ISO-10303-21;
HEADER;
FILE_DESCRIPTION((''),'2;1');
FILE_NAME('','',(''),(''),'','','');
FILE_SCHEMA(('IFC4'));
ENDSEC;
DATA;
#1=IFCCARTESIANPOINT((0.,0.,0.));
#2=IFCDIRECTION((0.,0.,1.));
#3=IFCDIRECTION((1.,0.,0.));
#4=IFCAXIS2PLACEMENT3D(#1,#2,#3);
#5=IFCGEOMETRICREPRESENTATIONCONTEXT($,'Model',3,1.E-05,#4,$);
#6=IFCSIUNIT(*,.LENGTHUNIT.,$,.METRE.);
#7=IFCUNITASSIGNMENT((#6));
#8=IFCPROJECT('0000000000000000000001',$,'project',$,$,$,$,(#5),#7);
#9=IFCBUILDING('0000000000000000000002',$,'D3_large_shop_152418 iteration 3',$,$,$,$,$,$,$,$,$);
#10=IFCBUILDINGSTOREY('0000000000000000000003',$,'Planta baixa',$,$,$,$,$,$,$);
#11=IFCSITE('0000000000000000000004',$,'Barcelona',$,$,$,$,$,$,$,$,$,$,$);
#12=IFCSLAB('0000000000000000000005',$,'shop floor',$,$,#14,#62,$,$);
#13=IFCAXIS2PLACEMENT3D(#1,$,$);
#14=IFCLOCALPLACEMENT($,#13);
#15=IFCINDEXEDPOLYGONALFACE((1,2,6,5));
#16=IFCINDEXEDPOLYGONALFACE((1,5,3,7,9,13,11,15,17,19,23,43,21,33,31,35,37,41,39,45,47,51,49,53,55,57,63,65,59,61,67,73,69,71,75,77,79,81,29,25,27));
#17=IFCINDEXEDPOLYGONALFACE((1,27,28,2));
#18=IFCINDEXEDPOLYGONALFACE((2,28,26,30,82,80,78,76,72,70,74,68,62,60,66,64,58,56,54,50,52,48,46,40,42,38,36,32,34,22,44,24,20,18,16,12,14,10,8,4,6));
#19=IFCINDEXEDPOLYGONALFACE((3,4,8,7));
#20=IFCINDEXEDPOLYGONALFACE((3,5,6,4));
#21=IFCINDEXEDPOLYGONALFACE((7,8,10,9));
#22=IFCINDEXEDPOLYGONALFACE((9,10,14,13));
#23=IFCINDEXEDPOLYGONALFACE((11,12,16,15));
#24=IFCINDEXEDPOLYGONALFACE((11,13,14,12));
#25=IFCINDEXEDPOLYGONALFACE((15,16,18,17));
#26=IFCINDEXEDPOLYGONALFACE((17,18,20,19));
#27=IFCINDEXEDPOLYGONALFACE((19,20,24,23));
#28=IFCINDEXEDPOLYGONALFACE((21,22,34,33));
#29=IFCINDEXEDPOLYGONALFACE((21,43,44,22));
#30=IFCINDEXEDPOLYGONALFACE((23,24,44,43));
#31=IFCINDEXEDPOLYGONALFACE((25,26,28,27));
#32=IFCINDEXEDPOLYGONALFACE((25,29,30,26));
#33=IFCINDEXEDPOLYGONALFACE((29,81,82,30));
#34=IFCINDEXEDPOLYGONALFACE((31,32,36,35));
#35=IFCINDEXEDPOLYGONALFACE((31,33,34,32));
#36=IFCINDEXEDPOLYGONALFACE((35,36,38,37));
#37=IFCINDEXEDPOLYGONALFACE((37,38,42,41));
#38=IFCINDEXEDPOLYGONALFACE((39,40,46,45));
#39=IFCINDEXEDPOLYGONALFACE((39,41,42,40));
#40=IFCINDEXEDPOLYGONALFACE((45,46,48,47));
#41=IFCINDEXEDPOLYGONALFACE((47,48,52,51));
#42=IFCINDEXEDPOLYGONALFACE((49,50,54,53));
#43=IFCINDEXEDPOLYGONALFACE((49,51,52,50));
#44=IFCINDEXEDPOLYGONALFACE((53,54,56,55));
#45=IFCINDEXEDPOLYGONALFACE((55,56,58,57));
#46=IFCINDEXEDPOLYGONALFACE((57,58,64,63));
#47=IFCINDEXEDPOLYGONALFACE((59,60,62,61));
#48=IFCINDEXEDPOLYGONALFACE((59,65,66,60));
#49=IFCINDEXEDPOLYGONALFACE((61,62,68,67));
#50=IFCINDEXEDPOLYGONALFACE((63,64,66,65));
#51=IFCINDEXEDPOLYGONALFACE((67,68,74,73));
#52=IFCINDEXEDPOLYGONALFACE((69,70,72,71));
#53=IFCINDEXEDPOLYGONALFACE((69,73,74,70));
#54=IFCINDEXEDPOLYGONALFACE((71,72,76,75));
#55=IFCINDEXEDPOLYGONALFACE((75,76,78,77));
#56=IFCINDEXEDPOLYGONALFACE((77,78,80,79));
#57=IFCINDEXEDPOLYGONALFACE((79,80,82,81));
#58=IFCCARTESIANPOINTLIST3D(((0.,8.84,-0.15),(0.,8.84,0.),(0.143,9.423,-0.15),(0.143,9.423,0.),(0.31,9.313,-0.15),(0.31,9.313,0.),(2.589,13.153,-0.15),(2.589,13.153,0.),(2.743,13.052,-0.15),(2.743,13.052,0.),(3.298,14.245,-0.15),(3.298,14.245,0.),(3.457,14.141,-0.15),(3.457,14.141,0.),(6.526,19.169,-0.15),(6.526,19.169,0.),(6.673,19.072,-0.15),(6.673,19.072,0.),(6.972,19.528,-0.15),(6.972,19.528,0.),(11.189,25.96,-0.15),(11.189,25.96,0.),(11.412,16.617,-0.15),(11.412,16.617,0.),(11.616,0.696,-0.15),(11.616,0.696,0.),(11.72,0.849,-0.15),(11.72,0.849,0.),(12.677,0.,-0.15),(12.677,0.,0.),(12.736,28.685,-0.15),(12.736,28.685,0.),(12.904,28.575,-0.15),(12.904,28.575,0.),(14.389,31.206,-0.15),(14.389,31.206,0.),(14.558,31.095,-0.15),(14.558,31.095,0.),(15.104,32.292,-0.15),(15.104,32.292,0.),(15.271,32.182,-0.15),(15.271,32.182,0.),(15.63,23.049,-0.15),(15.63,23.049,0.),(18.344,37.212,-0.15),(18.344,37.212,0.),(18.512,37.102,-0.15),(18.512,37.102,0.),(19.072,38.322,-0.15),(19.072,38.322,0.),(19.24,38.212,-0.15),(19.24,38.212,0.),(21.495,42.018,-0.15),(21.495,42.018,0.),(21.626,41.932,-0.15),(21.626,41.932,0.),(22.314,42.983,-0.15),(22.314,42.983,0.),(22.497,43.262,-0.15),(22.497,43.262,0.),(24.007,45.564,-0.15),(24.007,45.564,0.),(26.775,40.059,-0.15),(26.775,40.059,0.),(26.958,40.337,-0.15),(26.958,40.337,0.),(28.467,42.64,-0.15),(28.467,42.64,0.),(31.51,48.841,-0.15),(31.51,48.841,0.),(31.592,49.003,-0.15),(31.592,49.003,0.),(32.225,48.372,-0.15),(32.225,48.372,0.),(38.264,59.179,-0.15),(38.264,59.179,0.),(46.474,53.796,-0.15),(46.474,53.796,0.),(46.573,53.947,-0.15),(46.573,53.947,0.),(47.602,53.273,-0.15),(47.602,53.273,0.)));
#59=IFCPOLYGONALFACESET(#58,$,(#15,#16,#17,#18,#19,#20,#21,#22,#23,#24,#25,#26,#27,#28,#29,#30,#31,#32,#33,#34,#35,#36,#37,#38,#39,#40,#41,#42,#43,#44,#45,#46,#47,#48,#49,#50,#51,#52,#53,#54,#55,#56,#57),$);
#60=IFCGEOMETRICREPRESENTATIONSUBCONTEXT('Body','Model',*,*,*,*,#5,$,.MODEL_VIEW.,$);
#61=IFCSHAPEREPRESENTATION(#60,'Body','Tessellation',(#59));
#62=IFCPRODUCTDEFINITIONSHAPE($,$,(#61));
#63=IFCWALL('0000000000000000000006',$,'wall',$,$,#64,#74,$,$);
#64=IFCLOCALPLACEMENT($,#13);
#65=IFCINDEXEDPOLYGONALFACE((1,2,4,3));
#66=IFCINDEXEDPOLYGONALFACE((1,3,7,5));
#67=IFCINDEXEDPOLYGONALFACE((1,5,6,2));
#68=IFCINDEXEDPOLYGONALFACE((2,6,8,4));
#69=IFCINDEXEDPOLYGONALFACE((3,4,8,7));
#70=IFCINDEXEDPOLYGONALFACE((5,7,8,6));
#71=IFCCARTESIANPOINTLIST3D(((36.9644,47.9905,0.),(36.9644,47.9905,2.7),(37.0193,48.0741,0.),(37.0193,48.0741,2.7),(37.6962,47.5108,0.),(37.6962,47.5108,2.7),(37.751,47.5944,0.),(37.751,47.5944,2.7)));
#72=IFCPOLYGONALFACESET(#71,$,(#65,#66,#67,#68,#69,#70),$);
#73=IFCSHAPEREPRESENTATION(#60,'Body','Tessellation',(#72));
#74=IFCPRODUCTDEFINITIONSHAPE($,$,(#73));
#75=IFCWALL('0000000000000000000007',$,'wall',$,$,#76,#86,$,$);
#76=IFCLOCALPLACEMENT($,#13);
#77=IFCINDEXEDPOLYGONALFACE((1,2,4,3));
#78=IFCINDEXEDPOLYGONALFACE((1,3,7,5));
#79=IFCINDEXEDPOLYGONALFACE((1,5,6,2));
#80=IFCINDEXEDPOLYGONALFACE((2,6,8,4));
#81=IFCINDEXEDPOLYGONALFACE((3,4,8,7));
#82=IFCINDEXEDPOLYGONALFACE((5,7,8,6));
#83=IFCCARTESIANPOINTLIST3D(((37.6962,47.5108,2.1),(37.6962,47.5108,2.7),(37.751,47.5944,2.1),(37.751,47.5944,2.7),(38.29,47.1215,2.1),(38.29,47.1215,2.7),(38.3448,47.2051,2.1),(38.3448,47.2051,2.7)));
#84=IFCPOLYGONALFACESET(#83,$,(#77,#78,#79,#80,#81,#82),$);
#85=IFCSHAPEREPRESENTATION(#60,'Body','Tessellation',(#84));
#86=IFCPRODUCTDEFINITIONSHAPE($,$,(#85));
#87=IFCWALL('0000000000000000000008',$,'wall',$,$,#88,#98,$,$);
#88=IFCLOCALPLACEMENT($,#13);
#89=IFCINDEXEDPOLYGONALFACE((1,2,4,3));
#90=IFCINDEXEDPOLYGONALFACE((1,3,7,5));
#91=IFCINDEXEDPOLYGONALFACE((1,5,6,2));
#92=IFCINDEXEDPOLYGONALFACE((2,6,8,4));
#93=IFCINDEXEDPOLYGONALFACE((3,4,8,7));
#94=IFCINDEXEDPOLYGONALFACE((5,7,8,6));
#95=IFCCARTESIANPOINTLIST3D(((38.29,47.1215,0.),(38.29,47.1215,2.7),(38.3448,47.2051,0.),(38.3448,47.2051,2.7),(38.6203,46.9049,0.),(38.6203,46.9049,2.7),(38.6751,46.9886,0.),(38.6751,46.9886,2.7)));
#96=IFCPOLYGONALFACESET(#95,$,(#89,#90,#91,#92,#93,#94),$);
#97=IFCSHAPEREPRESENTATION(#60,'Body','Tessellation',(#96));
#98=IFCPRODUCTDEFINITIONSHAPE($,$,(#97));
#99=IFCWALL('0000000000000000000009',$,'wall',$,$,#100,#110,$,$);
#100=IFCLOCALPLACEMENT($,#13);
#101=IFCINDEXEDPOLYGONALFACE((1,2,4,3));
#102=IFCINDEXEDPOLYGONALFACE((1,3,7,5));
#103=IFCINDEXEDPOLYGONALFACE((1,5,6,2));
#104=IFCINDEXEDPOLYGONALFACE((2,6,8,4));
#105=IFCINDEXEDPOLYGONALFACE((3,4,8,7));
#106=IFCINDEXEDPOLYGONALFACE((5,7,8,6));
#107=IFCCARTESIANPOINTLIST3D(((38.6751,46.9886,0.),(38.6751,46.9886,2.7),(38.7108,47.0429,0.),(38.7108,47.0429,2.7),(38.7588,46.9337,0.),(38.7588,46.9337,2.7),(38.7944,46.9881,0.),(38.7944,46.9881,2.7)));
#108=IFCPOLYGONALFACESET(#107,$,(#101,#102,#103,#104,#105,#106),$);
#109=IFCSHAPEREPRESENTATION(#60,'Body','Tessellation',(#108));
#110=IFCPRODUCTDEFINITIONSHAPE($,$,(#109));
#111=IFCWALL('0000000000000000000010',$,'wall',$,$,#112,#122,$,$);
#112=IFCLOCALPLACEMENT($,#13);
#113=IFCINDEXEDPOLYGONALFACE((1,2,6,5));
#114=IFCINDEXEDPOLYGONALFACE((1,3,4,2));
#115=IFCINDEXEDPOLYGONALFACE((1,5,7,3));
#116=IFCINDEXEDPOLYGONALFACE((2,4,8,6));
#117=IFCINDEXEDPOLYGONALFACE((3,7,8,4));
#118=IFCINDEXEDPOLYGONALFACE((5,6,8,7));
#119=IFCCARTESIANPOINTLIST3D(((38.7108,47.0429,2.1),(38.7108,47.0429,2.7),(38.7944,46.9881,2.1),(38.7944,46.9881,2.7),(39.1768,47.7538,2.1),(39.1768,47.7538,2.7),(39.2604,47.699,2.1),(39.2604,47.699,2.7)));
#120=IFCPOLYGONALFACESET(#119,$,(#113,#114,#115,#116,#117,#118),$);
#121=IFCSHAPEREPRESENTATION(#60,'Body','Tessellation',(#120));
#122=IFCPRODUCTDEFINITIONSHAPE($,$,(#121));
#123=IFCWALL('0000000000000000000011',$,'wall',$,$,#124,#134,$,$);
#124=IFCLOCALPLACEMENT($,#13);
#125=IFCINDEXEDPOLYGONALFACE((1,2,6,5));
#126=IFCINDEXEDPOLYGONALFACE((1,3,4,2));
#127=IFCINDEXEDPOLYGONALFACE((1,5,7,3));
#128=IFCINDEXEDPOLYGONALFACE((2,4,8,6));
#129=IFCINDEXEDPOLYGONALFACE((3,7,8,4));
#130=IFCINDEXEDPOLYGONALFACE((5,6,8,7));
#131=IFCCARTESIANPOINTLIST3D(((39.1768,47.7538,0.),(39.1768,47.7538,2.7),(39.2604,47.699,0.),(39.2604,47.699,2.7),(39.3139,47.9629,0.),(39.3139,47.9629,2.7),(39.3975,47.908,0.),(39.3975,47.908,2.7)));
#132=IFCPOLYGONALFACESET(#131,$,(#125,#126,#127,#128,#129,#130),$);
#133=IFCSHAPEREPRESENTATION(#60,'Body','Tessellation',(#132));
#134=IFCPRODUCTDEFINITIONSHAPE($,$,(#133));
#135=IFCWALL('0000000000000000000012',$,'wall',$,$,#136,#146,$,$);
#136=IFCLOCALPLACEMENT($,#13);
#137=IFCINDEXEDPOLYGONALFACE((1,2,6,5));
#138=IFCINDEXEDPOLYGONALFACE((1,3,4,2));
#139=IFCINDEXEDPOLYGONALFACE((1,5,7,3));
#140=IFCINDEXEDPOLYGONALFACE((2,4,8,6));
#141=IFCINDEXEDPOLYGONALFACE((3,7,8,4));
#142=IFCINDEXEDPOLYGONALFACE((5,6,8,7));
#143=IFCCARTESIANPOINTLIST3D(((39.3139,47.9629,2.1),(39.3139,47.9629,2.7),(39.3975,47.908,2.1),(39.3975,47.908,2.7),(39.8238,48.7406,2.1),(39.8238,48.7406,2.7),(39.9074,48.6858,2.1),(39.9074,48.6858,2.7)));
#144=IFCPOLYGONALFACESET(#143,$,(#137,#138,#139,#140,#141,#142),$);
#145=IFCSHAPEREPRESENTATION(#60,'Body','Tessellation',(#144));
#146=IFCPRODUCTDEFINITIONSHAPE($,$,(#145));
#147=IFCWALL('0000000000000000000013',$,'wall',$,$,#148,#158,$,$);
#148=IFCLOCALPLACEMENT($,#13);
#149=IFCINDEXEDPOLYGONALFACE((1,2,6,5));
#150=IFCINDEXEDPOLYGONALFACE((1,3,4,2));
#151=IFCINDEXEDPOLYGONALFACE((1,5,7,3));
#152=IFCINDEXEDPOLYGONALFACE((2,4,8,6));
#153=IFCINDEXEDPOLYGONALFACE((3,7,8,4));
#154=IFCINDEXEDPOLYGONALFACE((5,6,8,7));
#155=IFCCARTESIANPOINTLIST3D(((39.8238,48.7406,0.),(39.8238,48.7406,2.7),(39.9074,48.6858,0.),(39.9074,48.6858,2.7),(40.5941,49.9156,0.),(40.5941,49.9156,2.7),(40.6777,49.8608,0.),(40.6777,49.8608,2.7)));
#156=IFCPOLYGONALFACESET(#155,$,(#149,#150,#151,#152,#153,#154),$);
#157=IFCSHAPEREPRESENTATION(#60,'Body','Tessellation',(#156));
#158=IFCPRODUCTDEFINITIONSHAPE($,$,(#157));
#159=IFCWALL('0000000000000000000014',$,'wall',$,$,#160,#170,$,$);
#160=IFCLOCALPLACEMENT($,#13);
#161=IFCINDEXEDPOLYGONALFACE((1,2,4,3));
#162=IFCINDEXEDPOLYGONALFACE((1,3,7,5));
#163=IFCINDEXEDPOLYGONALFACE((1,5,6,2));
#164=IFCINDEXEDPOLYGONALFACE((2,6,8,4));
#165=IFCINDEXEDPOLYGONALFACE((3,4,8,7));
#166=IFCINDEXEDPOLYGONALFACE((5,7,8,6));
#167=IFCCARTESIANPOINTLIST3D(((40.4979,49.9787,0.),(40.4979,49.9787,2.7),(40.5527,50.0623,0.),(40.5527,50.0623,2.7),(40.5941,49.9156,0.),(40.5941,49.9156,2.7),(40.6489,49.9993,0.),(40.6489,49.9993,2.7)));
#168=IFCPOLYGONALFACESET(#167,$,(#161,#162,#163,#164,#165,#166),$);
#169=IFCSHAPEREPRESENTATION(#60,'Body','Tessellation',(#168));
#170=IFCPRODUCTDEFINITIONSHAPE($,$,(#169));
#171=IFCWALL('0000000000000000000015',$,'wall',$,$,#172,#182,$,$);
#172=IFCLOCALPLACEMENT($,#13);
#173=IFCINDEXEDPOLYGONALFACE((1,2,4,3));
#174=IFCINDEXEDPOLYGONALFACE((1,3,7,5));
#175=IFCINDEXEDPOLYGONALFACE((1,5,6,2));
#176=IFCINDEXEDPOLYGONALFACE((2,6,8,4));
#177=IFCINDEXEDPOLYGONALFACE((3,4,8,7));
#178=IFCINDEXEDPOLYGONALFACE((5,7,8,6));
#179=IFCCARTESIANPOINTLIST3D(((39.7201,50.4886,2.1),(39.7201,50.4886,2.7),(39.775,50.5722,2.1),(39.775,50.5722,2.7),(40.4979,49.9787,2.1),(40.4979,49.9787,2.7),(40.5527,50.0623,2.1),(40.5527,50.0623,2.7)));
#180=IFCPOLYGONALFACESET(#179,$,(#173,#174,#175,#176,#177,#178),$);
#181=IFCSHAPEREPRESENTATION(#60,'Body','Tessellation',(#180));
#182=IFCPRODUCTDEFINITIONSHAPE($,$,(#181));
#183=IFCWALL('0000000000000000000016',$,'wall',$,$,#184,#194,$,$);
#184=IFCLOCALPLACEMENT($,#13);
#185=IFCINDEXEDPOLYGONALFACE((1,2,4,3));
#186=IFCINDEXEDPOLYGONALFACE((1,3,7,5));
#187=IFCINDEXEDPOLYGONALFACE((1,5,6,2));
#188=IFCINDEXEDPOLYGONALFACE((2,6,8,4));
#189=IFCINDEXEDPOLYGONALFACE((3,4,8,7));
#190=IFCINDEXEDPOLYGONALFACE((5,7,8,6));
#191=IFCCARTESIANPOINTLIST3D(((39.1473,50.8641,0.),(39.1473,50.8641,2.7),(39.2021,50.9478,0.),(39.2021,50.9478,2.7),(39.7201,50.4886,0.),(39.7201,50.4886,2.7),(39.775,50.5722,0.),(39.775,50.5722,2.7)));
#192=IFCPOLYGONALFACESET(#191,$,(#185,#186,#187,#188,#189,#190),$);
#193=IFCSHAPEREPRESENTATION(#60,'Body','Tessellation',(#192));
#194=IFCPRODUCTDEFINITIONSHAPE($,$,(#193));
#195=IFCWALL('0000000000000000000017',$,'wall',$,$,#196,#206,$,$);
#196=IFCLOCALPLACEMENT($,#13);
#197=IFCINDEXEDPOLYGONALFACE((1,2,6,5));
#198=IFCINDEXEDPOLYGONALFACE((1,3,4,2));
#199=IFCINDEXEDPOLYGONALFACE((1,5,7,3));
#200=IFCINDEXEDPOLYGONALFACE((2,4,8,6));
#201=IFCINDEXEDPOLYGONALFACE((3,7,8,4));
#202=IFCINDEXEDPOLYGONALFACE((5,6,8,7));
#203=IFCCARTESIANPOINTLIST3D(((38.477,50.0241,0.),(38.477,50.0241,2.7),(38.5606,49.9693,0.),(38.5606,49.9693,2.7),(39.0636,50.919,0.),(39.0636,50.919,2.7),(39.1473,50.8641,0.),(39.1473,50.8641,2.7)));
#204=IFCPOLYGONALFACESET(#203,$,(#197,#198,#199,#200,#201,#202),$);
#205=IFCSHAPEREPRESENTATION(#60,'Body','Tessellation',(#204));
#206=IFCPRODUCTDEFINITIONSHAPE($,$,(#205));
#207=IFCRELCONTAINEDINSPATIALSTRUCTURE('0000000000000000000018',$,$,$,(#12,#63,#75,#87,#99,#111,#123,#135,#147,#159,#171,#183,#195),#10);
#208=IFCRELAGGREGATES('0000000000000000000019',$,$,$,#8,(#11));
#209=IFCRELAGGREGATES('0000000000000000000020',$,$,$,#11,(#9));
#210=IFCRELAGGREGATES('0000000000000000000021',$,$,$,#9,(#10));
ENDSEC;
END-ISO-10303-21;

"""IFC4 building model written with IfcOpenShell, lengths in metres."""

from ifc_helpers import new_model, si_unit, frame, origin, origin_with_axes, place, context, subcontext, project, spatial, polyline, outline, extrude, element, save


model = new_model("IFC4")

# Units and contexts
model_context = context("Model", 3, precision=1e-05, world=origin_with_axes())
body_context = subcontext(model_context, "Body", "Model", "MODEL_VIEW")
ifc_project = project(units=[si_unit("LENGTHUNIT", "METRE")], contexts=[model_context])

# Site, building, storey
site = spatial("IfcSite", under=ifc_project, Name="Barcelona")
building = spatial("IfcBuilding", under=site, Name="D3_large_shop_152418 iteration 3")
storey = spatial("IfcBuildingStorey", under=building, Name="Planta baixa")

# Slab
slab_placement = place(None, origin_with_axes())
element("IfcSlab", 1, at=slab_placement, inside=storey, Name="shop floor", context=body_context, shape_type="SweptSolid", body=[
    extrude(outline(polyline([(15.63, 23.049), (11.189, 25.96), (12.904, 28.575), (12.736, 28.685), (14.389, 31.206), (14.558, 31.095), (15.271, 32.182), (15.104, 32.292), (18.344, 37.212), (18.512, 37.102), (19.24, 38.212), (19.072, 38.322), (21.495, 42.018), (21.626, 41.932), (22.314, 42.983), (26.775, 40.059), (26.958, 40.337), (22.497, 43.262), (24.007, 45.564), (28.467, 42.64), (32.225, 48.372), (31.51, 48.841), (31.592, 49.003), (38.264, 59.179), (46.474, 53.796), (46.573, 53.947), (47.602, 53.273), (12.677, 0.0), (11.616, 0.696), (11.72, 0.849), (0.0, 8.84), (0.31, 9.313), (0.143, 9.423), (2.589, 13.153), (2.743, 13.052), (3.457, 14.141), (3.298, 14.245), (6.526, 19.169), (6.673, 19.072), (6.972, 19.528), (11.412, 16.617), (15.63, 23.049)])), frame((0.0, 0.0, -0.15)), (0.0, 0.0, 1.0), 0.15),
])

# Walls
wall_1_placement = place(None, origin_with_axes())
element("IfcWall", 2, at=wall_1_placement, inside=storey, Name="wall", context=body_context, shape_type="SweptSolid", body=[
    extrude(outline(polyline([(37.0193, 48.0741), (37.751, 47.5944), (37.6962, 47.5108), (36.9644, 47.9905), (37.0193, 48.0741)])), origin(), (0.0, 0.0, 1.0), 2.7),
])
wall_2_placement = place(None, origin_with_axes())
element("IfcWall", 3, at=wall_2_placement, inside=storey, Name="wall", context=body_context, shape_type="SweptSolid", body=[
    extrude(outline(polyline([(37.751, 47.5944), (38.3448, 47.2051), (38.29, 47.1215), (37.6962, 47.5108), (37.751, 47.5944)])), frame((0.0, 0.0, 2.1)), (0.0, 0.0, 1.0), 0.6),
])
wall_3_placement = place(None, origin_with_axes())
element("IfcWall", 4, at=wall_3_placement, inside=storey, Name="wall", context=body_context, shape_type="SweptSolid", body=[
    extrude(outline(polyline([(38.3448, 47.2051), (38.6751, 46.9886), (38.6203, 46.9049), (38.29, 47.1215), (38.3448, 47.2051)])), origin(), (0.0, 0.0, 1.0), 2.7),
])
wall_4_placement = place(None, origin_with_axes())
element("IfcWall", 5, at=wall_4_placement, inside=storey, Name="wall", context=body_context, shape_type="SweptSolid", body=[
    extrude(outline(polyline([(38.6751, 46.9886), (38.7108, 47.0429), (38.7944, 46.9881), (38.7588, 46.9337), (38.6751, 46.9886)])), origin(), (0.0, 0.0, 1.0), 2.7),
])
wall_5_placement = place(None, origin_with_axes())
element("IfcWall", 6, at=wall_5_placement, inside=storey, Name="wall", context=body_context, shape_type="SweptSolid", body=[
    extrude(outline(polyline([(38.7108, 47.0429), (39.1768, 47.7538), (39.2604, 47.699), (38.7944, 46.9881), (38.7108, 47.0429)])), frame((0.0, 0.0, 2.1)), (0.0, 0.0, 1.0), 0.6),
])
wall_6_placement = place(None, origin_with_axes())
element("IfcWall", 7, at=wall_6_placement, inside=storey, Name="wall", context=body_context, shape_type="SweptSolid", body=[
    extrude(outline(polyline([(39.1768, 47.7538), (39.3139, 47.9629), (39.3975, 47.908), (39.2604, 47.699), (39.1768, 47.7538)])), origin(), (0.0, 0.0, 1.0), 2.7),
])
wall_7_placement = place(None, origin_with_axes())
element("IfcWall", 8, at=wall_7_placement, inside=storey, Name="wall", context=body_context, shape_type="SweptSolid", body=[
    extrude(outline(polyline([(39.3139, 47.9629), (39.8238, 48.7406), (39.9074, 48.6858), (39.3975, 47.908), (39.3139, 47.9629)])), frame((0.0, 0.0, 2.1)), (0.0, 0.0, 1.0), 0.6),
])
wall_8_placement = place(None, origin_with_axes())
element("IfcWall", 9, at=wall_8_placement, inside=storey, Name="wall", context=body_context, shape_type="SweptSolid", body=[
    extrude(outline(polyline([(39.8238, 48.7406), (40.5941, 49.9156), (40.6777, 49.8608), (39.9074, 48.6858), (39.8238, 48.7406)])), origin(), (0.0, 0.0, 1.0), 2.7),
])
wall_9_placement = place(None, origin_with_axes())
element("IfcWall", 10, at=wall_9_placement, inside=storey, Name="wall", context=body_context, shape_type="SweptSolid", body=[
    extrude(outline(polyline([(40.5941, 49.9156), (40.4979, 49.9787), (40.5527, 50.0623), (40.6489, 49.9993), (40.5941, 49.9156)])), origin(), (0.0, 0.0, 1.0), 2.7),
])
wall_10_placement = place(None, origin_with_axes())
element("IfcWall", 11, at=wall_10_placement, inside=storey, Name="wall", context=body_context, shape_type="SweptSolid", body=[
    extrude(outline(polyline([(40.4979, 49.9787), (39.7201, 50.4886), (39.775, 50.5722), (40.5527, 50.0623), (40.4979, 49.9787)])), frame((0.0, 0.0, 2.1)), (0.0, 0.0, 1.0), 0.6),
])
wall_11_placement = place(None, origin_with_axes())
element("IfcWall", 12, at=wall_11_placement, inside=storey, Name="wall", context=body_context, shape_type="SweptSolid", body=[
    extrude(outline(polyline([(39.7201, 50.4886), (39.1473, 50.8641), (39.2021, 50.9478), (39.775, 50.5722), (39.7201, 50.4886)])), origin(), (0.0, 0.0, 1.0), 2.7),
])
wall_12_placement = place(None, origin_with_axes())
element("IfcWall", 13, at=wall_12_placement, inside=storey, Name="wall", context=body_context, shape_type="SweptSolid", body=[
    extrude(outline(polyline([(39.1473, 50.8641), (38.5606, 49.9693), (38.477, 50.0241), (39.0636, 50.919), (39.1473, 50.8641)])), origin(), (0.0, 0.0, 1.0), 2.7),
])

save(model, "model.ifc")
